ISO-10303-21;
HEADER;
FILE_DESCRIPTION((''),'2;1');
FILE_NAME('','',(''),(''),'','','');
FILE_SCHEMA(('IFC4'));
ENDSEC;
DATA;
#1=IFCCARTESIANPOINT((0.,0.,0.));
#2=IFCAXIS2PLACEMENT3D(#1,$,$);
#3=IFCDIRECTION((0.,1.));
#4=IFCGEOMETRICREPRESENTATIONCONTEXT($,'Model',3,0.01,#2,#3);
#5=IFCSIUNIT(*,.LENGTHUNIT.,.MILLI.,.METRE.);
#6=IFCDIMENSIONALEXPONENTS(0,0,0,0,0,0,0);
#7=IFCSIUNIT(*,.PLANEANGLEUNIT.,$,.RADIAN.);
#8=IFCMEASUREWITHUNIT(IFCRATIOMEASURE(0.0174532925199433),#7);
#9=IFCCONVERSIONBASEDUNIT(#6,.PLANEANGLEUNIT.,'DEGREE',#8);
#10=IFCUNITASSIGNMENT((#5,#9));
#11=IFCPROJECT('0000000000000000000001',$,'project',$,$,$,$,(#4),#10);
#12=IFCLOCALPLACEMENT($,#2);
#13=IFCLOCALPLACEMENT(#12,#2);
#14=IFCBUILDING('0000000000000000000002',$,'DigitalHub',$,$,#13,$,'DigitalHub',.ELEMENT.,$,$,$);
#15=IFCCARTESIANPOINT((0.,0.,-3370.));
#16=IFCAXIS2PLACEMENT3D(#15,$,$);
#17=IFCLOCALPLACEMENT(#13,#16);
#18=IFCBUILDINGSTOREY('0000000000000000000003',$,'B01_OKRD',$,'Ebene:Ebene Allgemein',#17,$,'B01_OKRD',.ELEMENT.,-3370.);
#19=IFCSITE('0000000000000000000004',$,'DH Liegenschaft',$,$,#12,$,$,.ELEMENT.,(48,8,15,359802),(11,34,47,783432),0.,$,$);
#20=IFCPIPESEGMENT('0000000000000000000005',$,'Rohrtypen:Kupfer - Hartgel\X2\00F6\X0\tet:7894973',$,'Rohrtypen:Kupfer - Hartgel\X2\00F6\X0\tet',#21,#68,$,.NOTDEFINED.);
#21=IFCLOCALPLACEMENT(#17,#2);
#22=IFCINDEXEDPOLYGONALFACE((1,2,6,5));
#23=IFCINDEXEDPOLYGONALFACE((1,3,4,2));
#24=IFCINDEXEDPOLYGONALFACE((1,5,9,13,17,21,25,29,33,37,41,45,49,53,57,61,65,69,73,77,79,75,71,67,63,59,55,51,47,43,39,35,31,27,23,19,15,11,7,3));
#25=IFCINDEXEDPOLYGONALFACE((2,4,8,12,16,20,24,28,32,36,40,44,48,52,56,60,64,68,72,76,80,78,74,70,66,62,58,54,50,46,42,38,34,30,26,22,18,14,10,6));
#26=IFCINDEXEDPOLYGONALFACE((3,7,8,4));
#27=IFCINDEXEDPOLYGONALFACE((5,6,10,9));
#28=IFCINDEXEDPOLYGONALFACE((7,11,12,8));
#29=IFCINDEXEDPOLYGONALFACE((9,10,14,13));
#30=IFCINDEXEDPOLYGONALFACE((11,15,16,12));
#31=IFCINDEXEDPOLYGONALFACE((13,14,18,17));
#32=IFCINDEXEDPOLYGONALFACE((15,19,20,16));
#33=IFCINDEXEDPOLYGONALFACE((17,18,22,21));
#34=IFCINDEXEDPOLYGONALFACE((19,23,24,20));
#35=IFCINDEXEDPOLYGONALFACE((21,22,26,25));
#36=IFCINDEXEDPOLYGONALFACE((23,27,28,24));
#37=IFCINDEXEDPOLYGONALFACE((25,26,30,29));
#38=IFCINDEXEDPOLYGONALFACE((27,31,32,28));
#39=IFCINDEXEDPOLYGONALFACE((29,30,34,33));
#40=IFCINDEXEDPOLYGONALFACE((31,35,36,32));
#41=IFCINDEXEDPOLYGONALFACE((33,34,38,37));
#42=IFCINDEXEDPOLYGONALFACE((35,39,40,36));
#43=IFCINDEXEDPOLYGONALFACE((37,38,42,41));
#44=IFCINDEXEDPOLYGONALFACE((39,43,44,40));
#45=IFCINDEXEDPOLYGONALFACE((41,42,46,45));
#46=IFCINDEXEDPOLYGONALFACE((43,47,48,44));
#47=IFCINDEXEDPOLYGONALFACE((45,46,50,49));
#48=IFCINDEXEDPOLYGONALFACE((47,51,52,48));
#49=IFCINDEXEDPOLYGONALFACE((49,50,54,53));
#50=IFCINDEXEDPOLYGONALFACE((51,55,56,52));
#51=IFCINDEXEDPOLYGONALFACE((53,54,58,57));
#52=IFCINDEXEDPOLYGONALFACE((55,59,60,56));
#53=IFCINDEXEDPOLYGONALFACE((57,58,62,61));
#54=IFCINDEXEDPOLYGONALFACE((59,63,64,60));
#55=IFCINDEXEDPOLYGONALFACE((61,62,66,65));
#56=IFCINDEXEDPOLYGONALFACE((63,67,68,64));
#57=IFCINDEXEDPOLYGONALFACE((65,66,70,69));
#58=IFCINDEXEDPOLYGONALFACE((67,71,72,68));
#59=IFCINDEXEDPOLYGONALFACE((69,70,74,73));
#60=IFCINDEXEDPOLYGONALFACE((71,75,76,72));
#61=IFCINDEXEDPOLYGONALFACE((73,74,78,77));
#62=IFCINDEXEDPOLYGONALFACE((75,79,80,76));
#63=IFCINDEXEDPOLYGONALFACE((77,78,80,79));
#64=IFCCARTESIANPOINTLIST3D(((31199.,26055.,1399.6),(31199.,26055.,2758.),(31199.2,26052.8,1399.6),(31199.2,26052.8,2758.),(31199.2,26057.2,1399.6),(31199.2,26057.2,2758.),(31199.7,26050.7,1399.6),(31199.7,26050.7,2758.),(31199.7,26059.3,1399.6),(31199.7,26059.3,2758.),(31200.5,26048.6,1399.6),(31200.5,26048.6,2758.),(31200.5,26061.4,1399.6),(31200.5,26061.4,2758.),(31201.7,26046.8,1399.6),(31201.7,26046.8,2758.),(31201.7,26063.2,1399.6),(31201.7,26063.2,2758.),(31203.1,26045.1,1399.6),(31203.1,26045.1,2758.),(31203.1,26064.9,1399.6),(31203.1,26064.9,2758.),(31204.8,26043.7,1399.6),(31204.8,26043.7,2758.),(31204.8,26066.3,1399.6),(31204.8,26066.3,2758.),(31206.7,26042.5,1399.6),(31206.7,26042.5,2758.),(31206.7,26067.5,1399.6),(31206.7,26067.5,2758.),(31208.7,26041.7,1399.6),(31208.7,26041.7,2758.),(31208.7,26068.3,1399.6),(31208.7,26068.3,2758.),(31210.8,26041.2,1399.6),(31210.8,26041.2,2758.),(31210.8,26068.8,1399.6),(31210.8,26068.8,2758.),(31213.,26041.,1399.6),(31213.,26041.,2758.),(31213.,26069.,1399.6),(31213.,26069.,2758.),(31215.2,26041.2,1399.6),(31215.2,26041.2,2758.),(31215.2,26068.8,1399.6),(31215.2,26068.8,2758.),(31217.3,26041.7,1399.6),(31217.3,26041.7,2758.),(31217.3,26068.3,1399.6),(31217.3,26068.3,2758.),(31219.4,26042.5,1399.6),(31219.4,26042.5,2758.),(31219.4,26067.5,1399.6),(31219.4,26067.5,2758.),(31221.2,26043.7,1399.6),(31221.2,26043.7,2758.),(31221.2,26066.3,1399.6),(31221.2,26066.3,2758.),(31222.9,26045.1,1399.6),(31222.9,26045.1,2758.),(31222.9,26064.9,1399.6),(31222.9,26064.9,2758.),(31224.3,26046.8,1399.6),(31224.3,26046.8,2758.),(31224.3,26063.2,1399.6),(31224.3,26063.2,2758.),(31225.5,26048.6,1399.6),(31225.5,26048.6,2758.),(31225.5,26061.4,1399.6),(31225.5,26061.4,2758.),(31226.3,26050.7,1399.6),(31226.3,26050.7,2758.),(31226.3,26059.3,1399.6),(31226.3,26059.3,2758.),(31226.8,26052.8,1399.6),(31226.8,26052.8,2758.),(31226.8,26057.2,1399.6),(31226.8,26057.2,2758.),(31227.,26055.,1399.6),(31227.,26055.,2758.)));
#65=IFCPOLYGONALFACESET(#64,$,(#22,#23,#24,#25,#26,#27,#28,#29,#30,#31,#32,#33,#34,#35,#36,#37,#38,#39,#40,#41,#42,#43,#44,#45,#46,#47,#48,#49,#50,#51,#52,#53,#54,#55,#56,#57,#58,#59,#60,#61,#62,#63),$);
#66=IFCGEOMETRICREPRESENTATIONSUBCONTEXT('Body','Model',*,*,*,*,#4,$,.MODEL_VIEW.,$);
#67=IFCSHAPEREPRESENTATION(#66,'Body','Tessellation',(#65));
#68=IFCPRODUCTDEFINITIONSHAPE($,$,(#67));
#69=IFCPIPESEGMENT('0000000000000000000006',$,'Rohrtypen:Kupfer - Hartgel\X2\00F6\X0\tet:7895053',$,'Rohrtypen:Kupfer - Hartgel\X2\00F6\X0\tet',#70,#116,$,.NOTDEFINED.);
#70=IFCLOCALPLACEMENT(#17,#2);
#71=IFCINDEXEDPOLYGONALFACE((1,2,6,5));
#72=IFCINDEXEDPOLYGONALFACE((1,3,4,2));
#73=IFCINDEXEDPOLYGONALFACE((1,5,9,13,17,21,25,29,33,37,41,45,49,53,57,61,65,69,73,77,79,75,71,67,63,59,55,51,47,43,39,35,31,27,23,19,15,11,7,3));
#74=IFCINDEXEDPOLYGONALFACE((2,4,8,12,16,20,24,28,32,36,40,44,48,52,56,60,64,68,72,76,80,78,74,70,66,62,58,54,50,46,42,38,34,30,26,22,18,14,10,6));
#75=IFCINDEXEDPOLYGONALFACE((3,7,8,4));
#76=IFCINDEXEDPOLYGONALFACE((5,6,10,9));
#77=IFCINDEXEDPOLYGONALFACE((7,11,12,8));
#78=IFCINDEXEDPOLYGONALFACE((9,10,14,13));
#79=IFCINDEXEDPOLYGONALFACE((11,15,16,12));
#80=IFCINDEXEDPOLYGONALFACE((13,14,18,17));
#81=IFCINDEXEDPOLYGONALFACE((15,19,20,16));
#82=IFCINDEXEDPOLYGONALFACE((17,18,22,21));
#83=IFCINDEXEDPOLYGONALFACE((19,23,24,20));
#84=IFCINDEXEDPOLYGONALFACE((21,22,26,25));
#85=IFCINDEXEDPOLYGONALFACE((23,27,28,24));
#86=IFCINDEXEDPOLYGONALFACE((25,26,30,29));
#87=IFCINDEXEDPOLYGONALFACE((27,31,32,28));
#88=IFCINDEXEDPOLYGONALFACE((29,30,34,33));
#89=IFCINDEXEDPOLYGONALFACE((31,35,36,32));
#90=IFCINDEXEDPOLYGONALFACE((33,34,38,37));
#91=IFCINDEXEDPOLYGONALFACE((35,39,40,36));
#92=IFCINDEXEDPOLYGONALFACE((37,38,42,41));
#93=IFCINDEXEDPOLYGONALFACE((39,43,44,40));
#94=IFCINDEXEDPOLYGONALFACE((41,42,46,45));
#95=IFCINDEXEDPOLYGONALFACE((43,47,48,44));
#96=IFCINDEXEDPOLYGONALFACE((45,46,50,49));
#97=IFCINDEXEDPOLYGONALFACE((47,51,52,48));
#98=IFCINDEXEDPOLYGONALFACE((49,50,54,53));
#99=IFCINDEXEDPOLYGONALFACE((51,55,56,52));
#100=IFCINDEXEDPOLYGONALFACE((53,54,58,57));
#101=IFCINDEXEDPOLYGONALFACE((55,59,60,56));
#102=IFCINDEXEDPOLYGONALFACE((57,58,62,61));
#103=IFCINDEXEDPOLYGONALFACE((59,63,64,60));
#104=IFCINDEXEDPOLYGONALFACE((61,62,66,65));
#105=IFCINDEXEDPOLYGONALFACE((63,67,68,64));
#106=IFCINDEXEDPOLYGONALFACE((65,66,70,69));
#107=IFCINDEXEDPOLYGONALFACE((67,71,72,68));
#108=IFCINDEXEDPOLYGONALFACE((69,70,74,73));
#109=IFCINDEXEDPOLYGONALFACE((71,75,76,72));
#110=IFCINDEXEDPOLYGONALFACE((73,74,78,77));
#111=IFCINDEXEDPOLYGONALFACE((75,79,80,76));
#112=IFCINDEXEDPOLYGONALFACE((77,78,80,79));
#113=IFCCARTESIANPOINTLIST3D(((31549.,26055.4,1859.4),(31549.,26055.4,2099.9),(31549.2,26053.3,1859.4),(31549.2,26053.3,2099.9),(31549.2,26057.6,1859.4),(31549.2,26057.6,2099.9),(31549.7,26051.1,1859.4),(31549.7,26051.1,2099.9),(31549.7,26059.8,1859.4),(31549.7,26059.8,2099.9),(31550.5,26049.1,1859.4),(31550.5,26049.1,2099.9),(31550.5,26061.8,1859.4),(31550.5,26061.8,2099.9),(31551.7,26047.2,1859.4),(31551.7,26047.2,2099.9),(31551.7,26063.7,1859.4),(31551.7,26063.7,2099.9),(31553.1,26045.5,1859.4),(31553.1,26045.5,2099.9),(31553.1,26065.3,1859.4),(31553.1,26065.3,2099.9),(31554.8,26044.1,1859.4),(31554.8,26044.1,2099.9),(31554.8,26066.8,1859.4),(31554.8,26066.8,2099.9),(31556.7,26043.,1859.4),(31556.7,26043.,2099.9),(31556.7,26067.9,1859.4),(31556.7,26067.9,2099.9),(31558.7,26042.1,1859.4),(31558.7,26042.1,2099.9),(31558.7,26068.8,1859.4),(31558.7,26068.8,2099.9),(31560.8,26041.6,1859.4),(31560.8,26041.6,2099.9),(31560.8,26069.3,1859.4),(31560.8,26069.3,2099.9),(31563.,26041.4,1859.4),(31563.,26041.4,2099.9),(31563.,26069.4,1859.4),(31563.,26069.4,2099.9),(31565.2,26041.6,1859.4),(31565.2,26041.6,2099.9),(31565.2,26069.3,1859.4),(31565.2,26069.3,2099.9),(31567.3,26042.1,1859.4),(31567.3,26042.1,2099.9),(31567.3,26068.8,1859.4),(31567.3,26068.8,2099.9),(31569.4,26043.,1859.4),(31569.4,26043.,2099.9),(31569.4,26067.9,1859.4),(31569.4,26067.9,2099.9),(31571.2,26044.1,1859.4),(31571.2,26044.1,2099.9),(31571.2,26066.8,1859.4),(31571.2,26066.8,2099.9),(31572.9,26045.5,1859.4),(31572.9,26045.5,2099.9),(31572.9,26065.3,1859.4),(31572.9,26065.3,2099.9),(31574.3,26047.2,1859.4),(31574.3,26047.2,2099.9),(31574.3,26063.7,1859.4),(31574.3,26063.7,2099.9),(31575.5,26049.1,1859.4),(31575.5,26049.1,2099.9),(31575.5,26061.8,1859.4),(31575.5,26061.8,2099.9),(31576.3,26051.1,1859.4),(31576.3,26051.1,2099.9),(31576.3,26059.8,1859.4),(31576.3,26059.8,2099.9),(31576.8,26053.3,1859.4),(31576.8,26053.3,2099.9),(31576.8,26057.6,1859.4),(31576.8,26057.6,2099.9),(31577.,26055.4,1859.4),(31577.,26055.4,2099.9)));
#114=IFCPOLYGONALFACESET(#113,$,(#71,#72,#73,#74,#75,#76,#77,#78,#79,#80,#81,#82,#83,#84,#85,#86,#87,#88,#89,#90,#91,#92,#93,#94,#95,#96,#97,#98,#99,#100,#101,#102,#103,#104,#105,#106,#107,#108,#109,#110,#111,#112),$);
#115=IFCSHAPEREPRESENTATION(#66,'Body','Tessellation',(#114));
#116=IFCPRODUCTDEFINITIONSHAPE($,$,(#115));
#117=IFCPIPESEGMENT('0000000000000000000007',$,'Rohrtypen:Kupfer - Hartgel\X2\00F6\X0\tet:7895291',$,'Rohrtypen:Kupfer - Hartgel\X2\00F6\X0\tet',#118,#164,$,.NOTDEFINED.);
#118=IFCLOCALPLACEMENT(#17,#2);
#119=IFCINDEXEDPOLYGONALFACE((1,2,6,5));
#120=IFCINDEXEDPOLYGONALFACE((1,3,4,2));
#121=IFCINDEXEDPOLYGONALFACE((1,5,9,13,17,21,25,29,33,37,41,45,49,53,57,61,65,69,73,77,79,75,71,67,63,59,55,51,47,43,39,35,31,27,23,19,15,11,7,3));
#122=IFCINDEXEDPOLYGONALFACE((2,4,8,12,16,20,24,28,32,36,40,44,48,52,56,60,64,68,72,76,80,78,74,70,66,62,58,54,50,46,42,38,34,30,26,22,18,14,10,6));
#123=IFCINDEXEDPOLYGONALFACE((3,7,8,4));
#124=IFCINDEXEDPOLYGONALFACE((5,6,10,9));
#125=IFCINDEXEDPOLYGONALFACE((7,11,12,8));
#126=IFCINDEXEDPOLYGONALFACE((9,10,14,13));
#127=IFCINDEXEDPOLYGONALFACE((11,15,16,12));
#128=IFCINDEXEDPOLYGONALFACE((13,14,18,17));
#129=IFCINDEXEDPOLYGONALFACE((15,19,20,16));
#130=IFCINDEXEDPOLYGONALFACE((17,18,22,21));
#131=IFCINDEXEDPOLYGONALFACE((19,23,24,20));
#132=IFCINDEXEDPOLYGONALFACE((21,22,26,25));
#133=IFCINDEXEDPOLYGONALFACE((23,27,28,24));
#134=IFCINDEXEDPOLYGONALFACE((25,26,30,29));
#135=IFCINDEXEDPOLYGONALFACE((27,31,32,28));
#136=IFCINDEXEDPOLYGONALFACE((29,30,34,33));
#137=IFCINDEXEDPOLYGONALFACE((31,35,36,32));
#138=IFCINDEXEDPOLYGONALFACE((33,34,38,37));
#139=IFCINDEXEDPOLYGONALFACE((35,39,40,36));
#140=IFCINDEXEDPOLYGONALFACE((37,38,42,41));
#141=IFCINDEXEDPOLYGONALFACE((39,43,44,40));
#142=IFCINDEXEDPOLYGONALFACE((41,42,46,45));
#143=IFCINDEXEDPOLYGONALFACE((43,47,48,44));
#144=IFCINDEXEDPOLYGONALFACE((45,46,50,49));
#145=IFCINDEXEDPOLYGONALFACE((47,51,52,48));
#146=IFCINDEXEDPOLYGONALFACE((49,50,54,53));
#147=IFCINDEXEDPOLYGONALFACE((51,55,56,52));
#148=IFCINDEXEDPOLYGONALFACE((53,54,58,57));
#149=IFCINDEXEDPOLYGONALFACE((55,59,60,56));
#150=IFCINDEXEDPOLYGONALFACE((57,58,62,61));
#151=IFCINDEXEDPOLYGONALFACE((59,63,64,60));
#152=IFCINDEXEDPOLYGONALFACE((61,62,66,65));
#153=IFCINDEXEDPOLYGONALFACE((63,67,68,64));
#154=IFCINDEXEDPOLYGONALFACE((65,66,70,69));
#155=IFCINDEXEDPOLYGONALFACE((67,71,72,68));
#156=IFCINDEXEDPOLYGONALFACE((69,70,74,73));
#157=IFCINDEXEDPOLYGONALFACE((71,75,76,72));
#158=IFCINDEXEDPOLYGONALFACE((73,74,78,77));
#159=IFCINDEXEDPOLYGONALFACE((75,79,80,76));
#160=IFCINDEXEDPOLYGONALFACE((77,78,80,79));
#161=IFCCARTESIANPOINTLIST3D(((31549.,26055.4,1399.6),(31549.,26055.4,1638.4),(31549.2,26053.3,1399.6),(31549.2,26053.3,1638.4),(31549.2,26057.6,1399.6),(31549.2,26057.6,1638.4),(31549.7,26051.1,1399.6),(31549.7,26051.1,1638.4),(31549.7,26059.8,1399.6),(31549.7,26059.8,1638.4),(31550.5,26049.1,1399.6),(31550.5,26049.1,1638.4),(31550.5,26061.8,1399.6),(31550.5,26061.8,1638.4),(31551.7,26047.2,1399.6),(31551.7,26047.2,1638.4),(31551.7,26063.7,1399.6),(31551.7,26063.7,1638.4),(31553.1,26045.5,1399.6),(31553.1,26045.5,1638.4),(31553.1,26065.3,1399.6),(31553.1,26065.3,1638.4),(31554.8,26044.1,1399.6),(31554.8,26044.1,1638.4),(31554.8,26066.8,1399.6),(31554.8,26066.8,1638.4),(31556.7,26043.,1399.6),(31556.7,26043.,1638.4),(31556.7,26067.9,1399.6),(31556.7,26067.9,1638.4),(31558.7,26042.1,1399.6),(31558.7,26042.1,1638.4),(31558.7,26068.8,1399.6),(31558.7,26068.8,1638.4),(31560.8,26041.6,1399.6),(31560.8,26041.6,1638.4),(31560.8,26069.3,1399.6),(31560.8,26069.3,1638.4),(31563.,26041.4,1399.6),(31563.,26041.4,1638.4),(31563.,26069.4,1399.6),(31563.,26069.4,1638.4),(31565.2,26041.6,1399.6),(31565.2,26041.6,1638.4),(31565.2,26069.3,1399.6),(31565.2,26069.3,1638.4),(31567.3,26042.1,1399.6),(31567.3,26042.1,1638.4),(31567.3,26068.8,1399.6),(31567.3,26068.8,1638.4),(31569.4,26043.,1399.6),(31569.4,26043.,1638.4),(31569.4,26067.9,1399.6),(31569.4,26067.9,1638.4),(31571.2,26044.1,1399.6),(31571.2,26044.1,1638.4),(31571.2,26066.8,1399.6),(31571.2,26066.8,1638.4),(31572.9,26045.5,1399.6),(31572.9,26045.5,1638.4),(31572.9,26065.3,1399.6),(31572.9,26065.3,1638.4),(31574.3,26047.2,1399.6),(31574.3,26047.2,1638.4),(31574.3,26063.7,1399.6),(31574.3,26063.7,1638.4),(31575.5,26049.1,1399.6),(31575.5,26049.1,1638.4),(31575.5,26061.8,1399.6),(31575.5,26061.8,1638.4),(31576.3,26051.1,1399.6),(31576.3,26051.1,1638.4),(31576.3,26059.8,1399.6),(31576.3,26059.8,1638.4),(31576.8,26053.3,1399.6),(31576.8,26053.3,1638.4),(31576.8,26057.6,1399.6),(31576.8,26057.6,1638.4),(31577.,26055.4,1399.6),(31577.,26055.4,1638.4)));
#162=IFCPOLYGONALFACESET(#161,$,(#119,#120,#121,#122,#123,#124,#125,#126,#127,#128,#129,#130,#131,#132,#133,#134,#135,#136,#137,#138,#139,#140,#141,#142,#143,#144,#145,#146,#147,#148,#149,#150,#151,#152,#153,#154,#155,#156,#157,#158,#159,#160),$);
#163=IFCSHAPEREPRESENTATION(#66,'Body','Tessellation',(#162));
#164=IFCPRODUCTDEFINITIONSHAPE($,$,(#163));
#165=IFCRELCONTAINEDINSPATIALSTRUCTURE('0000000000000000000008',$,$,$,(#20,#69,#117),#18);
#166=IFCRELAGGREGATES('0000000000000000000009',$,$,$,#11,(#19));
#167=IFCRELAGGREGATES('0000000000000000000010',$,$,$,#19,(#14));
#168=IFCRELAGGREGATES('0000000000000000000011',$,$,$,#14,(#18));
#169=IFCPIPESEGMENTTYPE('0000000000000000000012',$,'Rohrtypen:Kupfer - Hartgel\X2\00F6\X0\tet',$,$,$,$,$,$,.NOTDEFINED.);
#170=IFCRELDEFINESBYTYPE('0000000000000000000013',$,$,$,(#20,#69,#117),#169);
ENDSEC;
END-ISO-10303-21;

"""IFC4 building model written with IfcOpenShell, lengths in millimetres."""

from ifc_helpers import new_model, entity, si_unit, converted_unit, direction, frame, origin, place, context, subcontext, project, spatial, indexed_curve, outline, extrude, type_object, element, save


model = new_model("IFC4")

# Units and contexts
model_context = context("Model", 3, precision=0.01, world=origin(), true_north=direction((0.0, 1.0)))
body_context = subcontext(model_context, "Body", "Model", "MODEL_VIEW")
ifc_project = project(units=[si_unit("LENGTHUNIT", "METRE", prefix="MILLI"), converted_unit("PLANEANGLEUNIT", "DEGREE", entity("IfcRatioMeasure", 0.0174532925199433), si_unit("PLANEANGLEUNIT", "RADIAN"), dimensions=[0, 0, 0, 0, 0, 0, 0])], contexts=[model_context])

# Site, building, storey
site_placement = place(None, origin())
site = spatial("IfcSite", under=ifc_project, at=site_placement, Name="DH Liegenschaft", CompositionType="ELEMENT", RefLatitude=(48, 8, 15, 359802), RefLongitude=(11, 34, 47, 783432), RefElevation=0.0)
building_placement = place(site_placement, origin())
building = spatial("IfcBuilding", under=site, at=building_placement, Name="DigitalHub", LongName="DigitalHub", CompositionType="ELEMENT")
storey_placement = place(building_placement, frame((0.0, 0.0, -3370.0)))
storey = spatial("IfcBuildingStorey", under=building, at=storey_placement, Name="B01_OKRD", ObjectType="Ebene:Ebene Allgemein", LongName="B01_OKRD", CompositionType="ELEMENT", Elevation=-3370.0)

# Pipe segments
pipe_segment_type = type_object("IfcPipeSegmentType", Name="Rohrtypen:Kupfer - Hartgelötet", PredefinedType="NOTDEFINED")
pipe_segment_1_placement = place(storey_placement, frame((31197.4, 26039.4, 1399.6)))
element("IfcPipeSegment", 1, at=pipe_segment_1_placement, inside=storey, type_object=pipe_segment_type, Name="Rohrtypen:Kupfer - Hartgelötet:7894973", ObjectType="Rohrtypen:Kupfer - Hartgelötet", PredefinedType="NOTDEFINED", context=body_context, shape_type="SweptSolid", body=[
    extrude(outline(indexed_curve([(14.0, 0.0), (13.8, 2.2), (13.3, 4.3), (12.5, 6.4), (11.3, 8.2), (9.9, 9.9), (8.2, 11.3), (6.4, 12.5), (4.3, 13.3), (2.2, 13.8), (0.0, 14.0), (-2.2, 13.8), (-4.3, 13.3), (-6.4, 12.5), (-8.2, 11.3), (-9.9, 9.9), (-11.3, 8.2), (-12.5, 6.4), (-13.3, 4.3), (-13.8, 2.2), (-14.0, 0.0), (-13.8, -2.2), (-13.3, -4.3), (-12.5, -6.4), (-11.3, -8.2), (-9.9, -9.9), (-8.2, -11.3), (-6.4, -12.5), (-4.3, -13.3), (-2.2, -13.8), (0.0, -14.0), (2.2, -13.8), (4.3, -13.3), (6.4, -12.5), (8.2, -11.3), (9.9, -9.9), (11.3, -8.2), (12.5, -6.4), (13.3, -4.3), (13.8, -2.2), (14.0, 0.0)], self_intersect=False)), frame((15.6, 15.6, 0.0), z_axis=(0.0, 0.0, 1.0), x_axis=(-1.0, 0.0, 0.0)), (0.0, 0.0, 1.0), 1358.4),
])
pipe_segment_2_placement = place(storey_placement, frame((31547.4, 26039.9, 1859.4)))
element("IfcPipeSegment", 2, at=pipe_segment_2_placement, inside=storey, type_object=pipe_segment_type, Name="Rohrtypen:Kupfer - Hartgelötet:7895053", ObjectType="Rohrtypen:Kupfer - Hartgelötet", PredefinedType="NOTDEFINED", context=body_context, shape_type="SweptSolid", body=[
    extrude(outline(indexed_curve([(14.0, 0.0), (13.8, 2.2), (13.3, 4.3), (12.5, 6.4), (11.3, 8.2), (9.9, 9.9), (8.2, 11.3), (6.4, 12.5), (4.3, 13.3), (2.2, 13.8), (0.0, 14.0), (-2.2, 13.8), (-4.3, 13.3), (-6.4, 12.5), (-8.2, 11.3), (-9.9, 9.9), (-11.3, 8.2), (-12.5, 6.4), (-13.3, 4.3), (-13.8, 2.2), (-14.0, 0.0), (-13.8, -2.2), (-13.3, -4.3), (-12.5, -6.4), (-11.3, -8.2), (-9.9, -9.9), (-8.2, -11.3), (-6.4, -12.5), (-4.3, -13.3), (-2.2, -13.8), (0.0, -14.0), (2.2, -13.8), (4.3, -13.3), (6.4, -12.5), (8.2, -11.3), (9.9, -9.9), (11.3, -8.2), (12.5, -6.4), (13.3, -4.3), (13.8, -2.2), (14.0, 0.0)], self_intersect=False)), frame((15.6, 15.6, 0.0)), (0.0, 0.0, 1.0), 240.5),
])
pipe_segment_3_placement = place(storey_placement, frame((31547.4, 26039.9, 1399.6)))
element("IfcPipeSegment", 3, at=pipe_segment_3_placement, inside=storey, type_object=pipe_segment_type, Name="Rohrtypen:Kupfer - Hartgelötet:7895291", ObjectType="Rohrtypen:Kupfer - Hartgelötet", PredefinedType="NOTDEFINED", context=body_context, shape_type="SweptSolid", body=[
    extrude(outline(indexed_curve([(14.0, 0.0), (13.8, 2.2), (13.3, 4.3), (12.5, 6.4), (11.3, 8.2), (9.9, 9.9), (8.2, 11.3), (6.4, 12.5), (4.3, 13.3), (2.2, 13.8), (0.0, 14.0), (-2.2, 13.8), (-4.3, 13.3), (-6.4, 12.5), (-8.2, 11.3), (-9.9, 9.9), (-11.3, 8.2), (-12.5, 6.4), (-13.3, 4.3), (-13.8, 2.2), (-14.0, 0.0), (-13.8, -2.2), (-13.3, -4.3), (-12.5, -6.4), (-11.3, -8.2), (-9.9, -9.9), (-8.2, -11.3), (-6.4, -12.5), (-4.3, -13.3), (-2.2, -13.8), (0.0, -14.0), (2.2, -13.8), (4.3, -13.3), (6.4, -12.5), (8.2, -11.3), (9.9, -9.9), (11.3, -8.2), (12.5, -6.4), (13.3, -4.3), (13.8, -2.2), (14.0, 0.0)], self_intersect=False)), frame((15.6, 15.6, 0.0), z_axis=(0.0, 0.0, 1.0), x_axis=(-1.0, 0.0, 0.0)), (0.0, 0.0, 1.0), 238.8),
])

save(model, "model.ifc")
